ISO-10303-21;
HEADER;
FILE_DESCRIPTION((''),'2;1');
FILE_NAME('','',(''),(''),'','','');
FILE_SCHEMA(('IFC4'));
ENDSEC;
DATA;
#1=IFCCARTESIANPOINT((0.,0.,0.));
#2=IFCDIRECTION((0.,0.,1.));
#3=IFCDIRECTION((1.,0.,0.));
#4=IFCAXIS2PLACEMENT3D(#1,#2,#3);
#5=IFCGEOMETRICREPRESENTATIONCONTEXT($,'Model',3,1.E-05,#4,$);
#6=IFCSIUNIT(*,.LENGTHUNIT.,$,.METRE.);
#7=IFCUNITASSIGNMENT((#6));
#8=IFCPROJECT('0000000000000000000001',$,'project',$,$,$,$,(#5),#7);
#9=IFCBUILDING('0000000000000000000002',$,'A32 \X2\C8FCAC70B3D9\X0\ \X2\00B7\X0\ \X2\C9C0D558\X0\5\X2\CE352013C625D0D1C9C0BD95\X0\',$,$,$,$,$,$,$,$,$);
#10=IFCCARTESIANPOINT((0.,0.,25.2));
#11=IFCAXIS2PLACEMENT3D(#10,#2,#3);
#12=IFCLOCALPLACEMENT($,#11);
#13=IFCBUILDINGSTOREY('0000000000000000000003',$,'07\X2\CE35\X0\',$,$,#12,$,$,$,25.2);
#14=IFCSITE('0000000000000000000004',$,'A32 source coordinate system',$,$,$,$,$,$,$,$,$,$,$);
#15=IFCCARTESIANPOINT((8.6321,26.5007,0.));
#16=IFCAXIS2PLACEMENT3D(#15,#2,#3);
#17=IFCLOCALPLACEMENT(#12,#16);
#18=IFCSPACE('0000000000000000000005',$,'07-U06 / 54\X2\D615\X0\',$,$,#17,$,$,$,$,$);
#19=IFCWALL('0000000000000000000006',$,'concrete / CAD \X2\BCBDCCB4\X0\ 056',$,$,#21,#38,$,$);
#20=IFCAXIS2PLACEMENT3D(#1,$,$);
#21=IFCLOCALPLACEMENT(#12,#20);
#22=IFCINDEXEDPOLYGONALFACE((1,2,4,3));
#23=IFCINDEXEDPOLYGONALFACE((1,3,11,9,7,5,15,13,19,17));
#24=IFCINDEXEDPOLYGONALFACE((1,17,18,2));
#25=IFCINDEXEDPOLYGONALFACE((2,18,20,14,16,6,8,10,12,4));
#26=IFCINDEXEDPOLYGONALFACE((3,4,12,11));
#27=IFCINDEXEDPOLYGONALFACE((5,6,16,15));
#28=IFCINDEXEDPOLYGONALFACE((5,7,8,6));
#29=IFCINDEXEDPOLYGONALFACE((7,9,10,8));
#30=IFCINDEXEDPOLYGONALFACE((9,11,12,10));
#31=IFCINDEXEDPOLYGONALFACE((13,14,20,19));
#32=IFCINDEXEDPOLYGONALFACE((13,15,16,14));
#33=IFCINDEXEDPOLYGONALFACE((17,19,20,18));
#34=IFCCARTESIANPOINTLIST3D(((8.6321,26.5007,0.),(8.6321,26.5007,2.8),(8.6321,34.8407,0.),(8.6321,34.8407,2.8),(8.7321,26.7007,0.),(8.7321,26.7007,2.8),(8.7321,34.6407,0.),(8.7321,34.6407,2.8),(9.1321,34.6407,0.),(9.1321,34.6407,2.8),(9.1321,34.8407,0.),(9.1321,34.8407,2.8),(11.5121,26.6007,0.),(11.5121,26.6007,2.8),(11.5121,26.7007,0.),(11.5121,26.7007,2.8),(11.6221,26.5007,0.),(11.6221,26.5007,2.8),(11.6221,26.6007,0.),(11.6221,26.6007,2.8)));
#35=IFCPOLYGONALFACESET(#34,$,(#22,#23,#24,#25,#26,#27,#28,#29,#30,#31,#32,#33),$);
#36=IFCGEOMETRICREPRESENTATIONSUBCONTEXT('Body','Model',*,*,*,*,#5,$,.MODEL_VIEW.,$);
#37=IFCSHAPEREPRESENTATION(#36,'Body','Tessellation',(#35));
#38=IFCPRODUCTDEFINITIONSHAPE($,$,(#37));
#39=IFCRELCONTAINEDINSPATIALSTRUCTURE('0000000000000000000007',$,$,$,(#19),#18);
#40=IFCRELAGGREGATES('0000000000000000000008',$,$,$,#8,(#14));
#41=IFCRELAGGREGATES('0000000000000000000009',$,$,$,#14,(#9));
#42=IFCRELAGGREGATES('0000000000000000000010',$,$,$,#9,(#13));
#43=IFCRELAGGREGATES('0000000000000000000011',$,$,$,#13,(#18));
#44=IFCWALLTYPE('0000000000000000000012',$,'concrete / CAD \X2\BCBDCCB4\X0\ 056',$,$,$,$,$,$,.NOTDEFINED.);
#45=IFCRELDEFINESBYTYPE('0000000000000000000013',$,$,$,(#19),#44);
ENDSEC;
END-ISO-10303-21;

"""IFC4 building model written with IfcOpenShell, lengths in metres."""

from ifc_helpers import new_model, si_unit, frame, origin, origin_with_axes, place, context, subcontext, project, spatial, polyline, outline, extrude, source, transform, mapped, type_object, type_shapes, element, save


model = new_model("IFC4")

# Units and contexts
model_context = context("Model", 3, precision=1e-05, world=origin_with_axes())
body_context = subcontext(model_context, "Body", "Model", "MODEL_VIEW")
ifc_project = project(units=[si_unit("LENGTHUNIT", "METRE")], contexts=[model_context])

# Site, building, storey, space
site = spatial("IfcSite", under=ifc_project, Name="A32 source coordinate system")
building = spatial("IfcBuilding", under=site, Name="A32 주거동 · 지하5층–옥탑지붕")
storey_placement = place(None, frame((0.0, 0.0, 25.2), z_axis=(0.0, 0.0, 1.0), x_axis=(1.0, 0.0, 0.0)))
storey = spatial("IfcBuildingStorey", under=building, at=storey_placement, Name="07층", Elevation=25.2)
space_placement = place(storey_placement, frame((8.6321, 26.5007, 0.0), z_axis=(0.0, 0.0, 1.0), x_axis=(1.0, 0.0, 0.0)))
space = spatial("IfcSpace", under=storey, at=space_placement, Name="07-U06 / 54형")

# Wall
wall_type_1 = type_object("IfcWallType", Name="concrete / CAD 벽체 056", PredefinedType="NOTDEFINED")
shared_shape_1 = source(origin(), body_context, "Body", "SweptSolid", [
    extrude(outline(polyline([(0.1, 8.14), (0.1, 0.2), (2.88, 0.2), (2.88, 0.1), (2.99, 0.1), (2.99, 0.0), (0.0, 0.0), (0.0, 8.34), (-0.35, 8.34), (-0.35, 8.34), (0.5, 8.34), (0.5, 8.14), (0.1, 8.14)])), origin(), (0.0, 0.0, 1.0), 2.8),
])
type_shapes(wall_type_1, [shared_shape_1])
wall_1_placement = place(space_placement, origin_with_axes())
element("IfcWall", 1, at=wall_1_placement, inside=space, type_object=wall_type_1, Name="concrete / CAD 벽체 056", context=body_context, shape_type="MappedRepresentation", body=[
    mapped(shared_shape_1, transform((0.0, 0.0, 0.0), scale=1.0)),
])

save(model, "model.ifc")
